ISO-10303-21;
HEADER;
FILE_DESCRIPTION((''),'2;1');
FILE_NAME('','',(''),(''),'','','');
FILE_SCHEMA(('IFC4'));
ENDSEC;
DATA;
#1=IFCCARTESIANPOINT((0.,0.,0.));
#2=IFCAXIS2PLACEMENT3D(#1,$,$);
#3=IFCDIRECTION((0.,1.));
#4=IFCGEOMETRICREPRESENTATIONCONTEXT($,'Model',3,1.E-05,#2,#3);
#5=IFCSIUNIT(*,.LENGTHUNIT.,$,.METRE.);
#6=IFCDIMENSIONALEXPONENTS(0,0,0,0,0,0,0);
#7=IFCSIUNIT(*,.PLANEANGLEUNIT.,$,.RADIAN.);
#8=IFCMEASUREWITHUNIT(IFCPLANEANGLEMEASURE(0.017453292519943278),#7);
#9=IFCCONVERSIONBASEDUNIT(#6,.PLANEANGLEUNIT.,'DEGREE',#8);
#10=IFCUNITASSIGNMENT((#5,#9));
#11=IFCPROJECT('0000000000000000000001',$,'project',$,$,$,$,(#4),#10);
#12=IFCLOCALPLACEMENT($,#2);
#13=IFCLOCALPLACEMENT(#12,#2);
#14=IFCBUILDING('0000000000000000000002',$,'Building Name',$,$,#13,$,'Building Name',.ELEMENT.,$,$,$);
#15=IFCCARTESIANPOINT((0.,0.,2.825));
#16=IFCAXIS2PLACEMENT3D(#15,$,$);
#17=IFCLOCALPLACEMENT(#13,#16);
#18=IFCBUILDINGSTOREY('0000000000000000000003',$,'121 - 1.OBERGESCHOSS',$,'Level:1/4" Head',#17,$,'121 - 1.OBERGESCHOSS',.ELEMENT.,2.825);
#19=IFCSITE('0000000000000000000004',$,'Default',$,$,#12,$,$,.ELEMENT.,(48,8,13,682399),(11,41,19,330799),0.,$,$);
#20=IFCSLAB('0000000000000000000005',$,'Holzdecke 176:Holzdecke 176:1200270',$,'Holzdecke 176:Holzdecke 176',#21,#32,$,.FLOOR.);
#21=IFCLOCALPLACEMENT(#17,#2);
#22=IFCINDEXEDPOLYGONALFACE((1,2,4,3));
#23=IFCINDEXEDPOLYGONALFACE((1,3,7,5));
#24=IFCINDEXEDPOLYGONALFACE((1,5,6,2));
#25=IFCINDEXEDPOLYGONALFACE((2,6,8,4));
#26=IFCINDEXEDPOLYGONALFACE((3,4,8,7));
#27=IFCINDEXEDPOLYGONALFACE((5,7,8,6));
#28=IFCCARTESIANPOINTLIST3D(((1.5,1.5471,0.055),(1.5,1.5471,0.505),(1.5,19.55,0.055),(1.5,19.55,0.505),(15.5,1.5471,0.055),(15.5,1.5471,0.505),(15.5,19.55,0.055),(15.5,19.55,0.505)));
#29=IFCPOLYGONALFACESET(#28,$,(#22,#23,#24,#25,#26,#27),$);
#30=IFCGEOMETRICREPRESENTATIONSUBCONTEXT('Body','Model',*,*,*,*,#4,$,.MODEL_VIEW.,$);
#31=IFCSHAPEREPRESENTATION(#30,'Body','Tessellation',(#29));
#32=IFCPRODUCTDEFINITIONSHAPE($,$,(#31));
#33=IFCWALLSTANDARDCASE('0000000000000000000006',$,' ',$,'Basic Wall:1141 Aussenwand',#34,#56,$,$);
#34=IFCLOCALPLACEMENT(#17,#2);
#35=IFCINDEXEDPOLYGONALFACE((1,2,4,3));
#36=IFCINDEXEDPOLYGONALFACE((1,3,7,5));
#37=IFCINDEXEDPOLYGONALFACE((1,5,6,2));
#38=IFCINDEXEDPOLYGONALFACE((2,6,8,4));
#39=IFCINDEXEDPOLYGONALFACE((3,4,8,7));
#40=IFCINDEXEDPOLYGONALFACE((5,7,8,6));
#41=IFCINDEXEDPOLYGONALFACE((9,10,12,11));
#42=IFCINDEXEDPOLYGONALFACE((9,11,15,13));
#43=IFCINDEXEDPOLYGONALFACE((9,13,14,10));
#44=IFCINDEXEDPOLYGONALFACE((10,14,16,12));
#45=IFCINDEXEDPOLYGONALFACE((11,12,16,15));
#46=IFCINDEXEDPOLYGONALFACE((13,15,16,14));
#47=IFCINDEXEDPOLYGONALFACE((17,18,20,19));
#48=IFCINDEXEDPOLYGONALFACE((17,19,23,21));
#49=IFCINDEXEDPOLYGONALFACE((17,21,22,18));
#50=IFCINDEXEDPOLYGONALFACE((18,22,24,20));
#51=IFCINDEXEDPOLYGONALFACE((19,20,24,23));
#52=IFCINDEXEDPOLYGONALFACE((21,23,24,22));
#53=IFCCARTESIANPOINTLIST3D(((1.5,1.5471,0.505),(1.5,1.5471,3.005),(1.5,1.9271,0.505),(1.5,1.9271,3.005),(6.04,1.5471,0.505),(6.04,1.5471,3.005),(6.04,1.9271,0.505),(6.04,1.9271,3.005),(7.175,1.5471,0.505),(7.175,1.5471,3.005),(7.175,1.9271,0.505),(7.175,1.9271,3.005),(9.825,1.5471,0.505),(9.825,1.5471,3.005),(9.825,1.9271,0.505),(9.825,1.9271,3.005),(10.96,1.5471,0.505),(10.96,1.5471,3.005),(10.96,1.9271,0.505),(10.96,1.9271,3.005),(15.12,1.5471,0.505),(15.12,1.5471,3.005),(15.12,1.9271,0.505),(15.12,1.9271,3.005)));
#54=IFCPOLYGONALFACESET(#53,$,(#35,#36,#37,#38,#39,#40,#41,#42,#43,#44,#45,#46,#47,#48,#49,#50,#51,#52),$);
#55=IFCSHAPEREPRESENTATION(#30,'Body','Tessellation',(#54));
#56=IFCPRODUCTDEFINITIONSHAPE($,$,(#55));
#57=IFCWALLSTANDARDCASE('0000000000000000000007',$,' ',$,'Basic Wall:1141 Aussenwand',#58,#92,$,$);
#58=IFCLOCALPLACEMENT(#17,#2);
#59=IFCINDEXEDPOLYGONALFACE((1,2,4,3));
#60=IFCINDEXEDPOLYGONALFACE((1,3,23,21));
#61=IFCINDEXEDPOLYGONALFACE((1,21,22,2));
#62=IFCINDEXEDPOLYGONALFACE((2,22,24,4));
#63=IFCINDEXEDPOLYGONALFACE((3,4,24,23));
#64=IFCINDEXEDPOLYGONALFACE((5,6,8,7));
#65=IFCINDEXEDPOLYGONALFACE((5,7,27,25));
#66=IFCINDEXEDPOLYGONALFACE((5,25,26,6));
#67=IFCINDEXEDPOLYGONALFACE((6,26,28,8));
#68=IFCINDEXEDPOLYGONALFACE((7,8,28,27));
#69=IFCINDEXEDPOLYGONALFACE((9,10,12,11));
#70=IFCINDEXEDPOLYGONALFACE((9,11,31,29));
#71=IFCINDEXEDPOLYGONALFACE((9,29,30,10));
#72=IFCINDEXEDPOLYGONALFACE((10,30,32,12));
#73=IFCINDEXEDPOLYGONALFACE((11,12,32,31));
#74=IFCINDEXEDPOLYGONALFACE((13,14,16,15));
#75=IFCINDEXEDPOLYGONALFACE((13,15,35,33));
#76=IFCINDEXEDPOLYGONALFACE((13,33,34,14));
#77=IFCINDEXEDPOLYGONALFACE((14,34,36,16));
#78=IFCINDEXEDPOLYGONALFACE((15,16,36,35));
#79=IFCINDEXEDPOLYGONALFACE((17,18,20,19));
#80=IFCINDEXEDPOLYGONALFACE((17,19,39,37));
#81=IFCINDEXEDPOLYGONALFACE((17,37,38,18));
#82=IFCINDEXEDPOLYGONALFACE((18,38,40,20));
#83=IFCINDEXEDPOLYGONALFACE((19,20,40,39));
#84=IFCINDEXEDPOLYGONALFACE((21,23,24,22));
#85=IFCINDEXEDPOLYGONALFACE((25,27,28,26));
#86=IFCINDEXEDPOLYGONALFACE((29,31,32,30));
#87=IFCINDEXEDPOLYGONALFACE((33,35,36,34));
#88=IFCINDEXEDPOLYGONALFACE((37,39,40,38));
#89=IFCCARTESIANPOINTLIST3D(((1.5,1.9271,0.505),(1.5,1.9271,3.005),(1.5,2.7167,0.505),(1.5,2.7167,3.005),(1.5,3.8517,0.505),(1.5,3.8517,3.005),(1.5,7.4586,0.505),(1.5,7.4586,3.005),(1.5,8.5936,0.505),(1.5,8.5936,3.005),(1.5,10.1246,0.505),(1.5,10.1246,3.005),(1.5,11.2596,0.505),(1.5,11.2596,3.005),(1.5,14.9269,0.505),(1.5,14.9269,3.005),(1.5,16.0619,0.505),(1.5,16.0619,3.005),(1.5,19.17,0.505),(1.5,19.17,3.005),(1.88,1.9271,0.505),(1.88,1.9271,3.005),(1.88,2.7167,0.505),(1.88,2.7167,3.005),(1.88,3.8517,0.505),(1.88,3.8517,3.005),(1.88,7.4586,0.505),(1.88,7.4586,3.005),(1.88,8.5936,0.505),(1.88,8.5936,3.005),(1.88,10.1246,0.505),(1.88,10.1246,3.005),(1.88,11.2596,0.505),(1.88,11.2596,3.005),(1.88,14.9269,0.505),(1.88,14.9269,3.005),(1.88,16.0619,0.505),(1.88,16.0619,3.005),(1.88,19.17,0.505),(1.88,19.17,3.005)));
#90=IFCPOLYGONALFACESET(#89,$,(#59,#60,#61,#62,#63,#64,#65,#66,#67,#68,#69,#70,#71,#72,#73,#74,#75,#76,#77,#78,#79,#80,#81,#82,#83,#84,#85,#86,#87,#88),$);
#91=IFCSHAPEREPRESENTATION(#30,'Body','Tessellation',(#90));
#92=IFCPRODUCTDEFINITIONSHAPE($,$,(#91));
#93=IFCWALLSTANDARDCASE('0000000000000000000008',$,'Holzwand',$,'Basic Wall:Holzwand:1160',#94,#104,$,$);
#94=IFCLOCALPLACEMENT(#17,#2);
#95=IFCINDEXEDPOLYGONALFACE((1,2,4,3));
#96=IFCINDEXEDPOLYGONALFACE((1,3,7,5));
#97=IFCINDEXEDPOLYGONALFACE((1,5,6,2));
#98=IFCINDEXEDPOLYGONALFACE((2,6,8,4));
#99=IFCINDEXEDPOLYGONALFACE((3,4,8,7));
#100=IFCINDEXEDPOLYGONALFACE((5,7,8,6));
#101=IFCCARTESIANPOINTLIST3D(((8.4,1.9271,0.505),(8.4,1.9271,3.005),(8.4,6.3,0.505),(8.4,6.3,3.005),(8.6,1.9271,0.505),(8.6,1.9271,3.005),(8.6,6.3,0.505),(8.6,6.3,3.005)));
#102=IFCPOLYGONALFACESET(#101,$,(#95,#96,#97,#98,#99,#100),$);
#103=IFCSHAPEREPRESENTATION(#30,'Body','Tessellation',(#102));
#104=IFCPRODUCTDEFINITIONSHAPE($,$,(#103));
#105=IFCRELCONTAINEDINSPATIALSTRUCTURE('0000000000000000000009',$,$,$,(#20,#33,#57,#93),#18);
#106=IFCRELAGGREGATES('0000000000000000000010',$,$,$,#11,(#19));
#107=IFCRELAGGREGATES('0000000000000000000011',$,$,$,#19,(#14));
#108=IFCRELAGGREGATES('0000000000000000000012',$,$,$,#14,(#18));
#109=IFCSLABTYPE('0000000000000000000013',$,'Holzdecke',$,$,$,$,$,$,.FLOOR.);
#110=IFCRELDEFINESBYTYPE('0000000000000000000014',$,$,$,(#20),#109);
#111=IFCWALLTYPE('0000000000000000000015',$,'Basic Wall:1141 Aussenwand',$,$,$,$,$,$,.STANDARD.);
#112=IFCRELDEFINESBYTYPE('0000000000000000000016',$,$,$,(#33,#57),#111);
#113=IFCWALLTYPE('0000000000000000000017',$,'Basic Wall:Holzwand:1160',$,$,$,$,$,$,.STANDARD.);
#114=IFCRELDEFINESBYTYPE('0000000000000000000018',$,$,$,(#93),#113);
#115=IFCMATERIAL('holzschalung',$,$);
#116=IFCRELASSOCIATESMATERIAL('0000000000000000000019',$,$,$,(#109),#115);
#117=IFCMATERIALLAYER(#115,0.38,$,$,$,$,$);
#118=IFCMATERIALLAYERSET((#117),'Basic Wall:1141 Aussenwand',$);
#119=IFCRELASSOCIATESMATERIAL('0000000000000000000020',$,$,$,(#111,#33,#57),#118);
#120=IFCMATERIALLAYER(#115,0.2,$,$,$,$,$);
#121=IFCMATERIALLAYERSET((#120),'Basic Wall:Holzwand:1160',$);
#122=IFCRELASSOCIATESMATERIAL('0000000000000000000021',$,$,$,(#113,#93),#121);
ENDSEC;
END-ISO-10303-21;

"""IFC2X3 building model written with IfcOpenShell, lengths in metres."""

from ifc_helpers import new_model, entity, si_unit, converted_unit, direction, frame, frame_2d, origin, place, context, subcontext, project, spatial, rectangle, extrude, material, layer, layer_set, layer_usage, type_object, element, save


model = new_model("IFC2X3")

# Units and contexts
model_context = context("Model", 3, precision=1e-05, world=origin(), true_north=direction((0.0, 1.0)))
body_context = subcontext(model_context, "Body", "Model", "MODEL_VIEW")
ifc_project = project(units=[si_unit("LENGTHUNIT", "METRE"), converted_unit("PLANEANGLEUNIT", "DEGREE", entity("IfcPlaneAngleMeasure", 0.017453292519943278), si_unit("PLANEANGLEUNIT", "RADIAN"), dimensions=[0, 0, 0, 0, 0, 0, 0])], contexts=[model_context])

# Site, building, storey
site_placement = place(None, origin())
site = spatial("IfcSite", under=ifc_project, at=site_placement, Name="Default", CompositionType="ELEMENT", RefLatitude=(48, 8, 13, 682399), RefLongitude=(11, 41, 19, 330799), RefElevation=0.0)
building_placement = place(site_placement, origin())
building = spatial("IfcBuilding", under=site, at=building_placement, Name="Building Name", LongName="Building Name", CompositionType="ELEMENT")
storey_placement = place(building_placement, frame((0.0, 0.0, 2.825)))
storey = spatial("IfcBuildingStorey", under=building, at=storey_placement, Name="121 - 1.OBERGESCHOSS", ObjectType="Level:1/4\" Head", LongName="121 - 1.OBERGESCHOSS", CompositionType="ELEMENT", Elevation=2.825)

# Slab
ifc_material_1 = material(Name="holzschalung")
slab_type = type_object("IfcSlabType", Name="Holzdecke", PredefinedType="FLOOR", material=ifc_material_1)
slab_placement = place(storey_placement, origin())
element("IfcSlab", 1, at=slab_placement, inside=storey, type_object=slab_type, Name="Holzdecke 176:Holzdecke 176:1200270", ObjectType="Holzdecke 176:Holzdecke 176", PredefinedType="FLOOR", context=body_context, shape_type="SweptSolid", body=[
    extrude(rectangle(XDim=14.0, YDim=18.0029, at=frame_2d((0.0, 0.0), x_axis=(1.0, 0.0))), frame((8.5, 10.5486, 0.055), z_axis=(0.0, 0.0, 1.0), x_axis=(-1.0, 0.0, 0.0)), (0.0, 0.0, 1.0), 0.45),
])

# Walls, openings
ifc_layer_1 = layer(ifc_material_1, 0.38)
ifc_layer_set_1 = layer_set([ifc_layer_1], Name="Basic Wall:1141 Aussenwand")
ifc_layer_usage_1 = layer_usage(ifc_layer_set_1, "AXIS2", "NEGATIVE", 0.19)
wall_type_1 = type_object("IfcWallType", Name="Basic Wall:1141 Aussenwand", PredefinedType="STANDARD", material=ifc_layer_set_1)
wall_1_placement = place(storey_placement, frame((15.12, 1.7371, 0.505), z_axis=(0.0, 0.0, 1.0), x_axis=(-1.0, 0.0, 0.0)))
wall_1 = element("IfcWallStandardCase", 2, at=wall_1_placement, inside=storey, type_object=wall_type_1, material=ifc_layer_usage_1, Name=" ", ObjectType="Basic Wall:1141 Aussenwand", context=body_context, shape_type="SweptSolid", body=[
    extrude(rectangle(XDim=13.62, YDim=0.38, at=frame_2d((6.81, 0.0), x_axis=(-1.0, 0.0))), origin(), (0.0, 0.0, 1.0), 2.5),
])
opening_1_placement = place(wall_1_placement, origin())
element("IfcOpeningElement", 3, at=opening_1_placement, cuts=wall_1, ObjectType="Opening", context=body_context, shape_type="SweptSolid", body=[
    extrude(rectangle(XDim=2.5, YDim=1.135, at=frame_2d((0.0, 0.0), x_axis=(1.0, 0.0))), frame((4.7275, -0.19, 1.25), z_axis=(0.0, 1.0, 0.0), x_axis=(0.0, 0.0, 1.0)), (0.0, 0.0, 1.0), 0.38),
])
opening_2_placement = place(wall_1_placement, origin())
element("IfcOpeningElement", 4, at=opening_2_placement, cuts=wall_1, ObjectType="Opening", context=body_context, shape_type="SweptSolid", body=[
    extrude(rectangle(XDim=2.5, YDim=1.135, at=frame_2d((0.0, 0.0), x_axis=(1.0, 0.0))), frame((8.5125, -0.19, 1.25), z_axis=(0.0, 1.0, 0.0), x_axis=(0.0, 0.0, 1.0)), (0.0, 0.0, 1.0), 0.38),
])
ifc_layer_usage_2 = layer_usage(ifc_layer_set_1, "AXIS2", "NEGATIVE", 0.19)
wall_2_placement = place(storey_placement, frame((1.69, 1.9271, 0.505), z_axis=(0.0, 0.0, 1.0), x_axis=(0.0, 1.0, 0.0)))
wall_2 = element("IfcWallStandardCase", 5, at=wall_2_placement, inside=storey, type_object=wall_type_1, material=ifc_layer_usage_2, Name=" ", ObjectType="Basic Wall:1141 Aussenwand", context=body_context, shape_type="SweptSolid", body=[
    extrude(rectangle(XDim=17.2429, YDim=0.38, at=frame_2d((8.6214, 0.0), x_axis=(-1.0, 0.0))), origin(), (0.0, 0.0, 1.0), 2.5),
])
opening_3_placement = place(wall_2_placement, origin())
element("IfcOpeningElement", 6, at=opening_3_placement, cuts=wall_2, ObjectType="Opening", context=body_context, shape_type="SweptSolid", body=[
    extrude(rectangle(XDim=2.5, YDim=1.135, at=frame_2d((0.0, 0.0), x_axis=(1.0, 0.0))), frame((13.5673, -0.19, 1.25), z_axis=(0.0, 1.0, 0.0), x_axis=(0.0, 0.0, 1.0)), (0.0, 0.0, 1.0), 0.38),
])
opening_4_placement = place(wall_2_placement, origin())
element("IfcOpeningElement", 7, at=opening_4_placement, cuts=wall_2, ObjectType="Opening", context=body_context, shape_type="SweptSolid", body=[
    extrude(rectangle(XDim=2.5, YDim=1.135, at=frame_2d((0.0, 0.0), x_axis=(1.0, 0.0))), frame((8.765, -0.19, 1.25), z_axis=(0.0, 1.0, 0.0), x_axis=(0.0, 0.0, 1.0)), (0.0, 0.0, 1.0), 0.38),
])
opening_5_placement = place(wall_2_placement, origin())
element("IfcOpeningElement", 8, at=opening_5_placement, cuts=wall_2, ObjectType="Opening", context=body_context, shape_type="SweptSolid", body=[
    extrude(rectangle(XDim=2.5, YDim=1.135, at=frame_2d((0.0, 0.0), x_axis=(1.0, 0.0))), frame((6.0989, -0.19, 1.25), z_axis=(0.0, 1.0, 0.0), x_axis=(0.0, 0.0, 1.0)), (0.0, 0.0, 1.0), 0.38),
])
opening_6_placement = place(wall_2_placement, origin())
element("IfcOpeningElement", 9, at=opening_6_placement, cuts=wall_2, ObjectType="Opening", context=body_context, shape_type="SweptSolid", body=[
    extrude(rectangle(XDim=2.5, YDim=1.135, at=frame_2d((0.0, 0.0), x_axis=(1.0, 0.0))), frame((1.3571, -0.19, 1.25), z_axis=(0.0, 1.0, 0.0), x_axis=(0.0, 0.0, 1.0)), (0.0, 0.0, 1.0), 0.38),
])

# Wall
ifc_layer_2 = layer(ifc_material_1, 0.2)
ifc_layer_set_2 = layer_set([ifc_layer_2], Name="Basic Wall:Holzwand:1160")
ifc_layer_usage_3 = layer_usage(ifc_layer_set_2, "AXIS2", "NEGATIVE", 0.1)
wall_type_2 = type_object("IfcWallType", Name="Basic Wall:Holzwand:1160", PredefinedType="STANDARD", material=ifc_layer_set_2)
wall_3_placement = place(storey_placement, frame((8.5, 1.9271, 0.505), z_axis=(0.0, 0.0, 1.0), x_axis=(0.0, 1.0, 0.0)))
element("IfcWallStandardCase", 10, at=wall_3_placement, inside=storey, type_object=wall_type_2, material=ifc_layer_usage_3, Name="Holzwand", ObjectType="Basic Wall:Holzwand:1160", context=body_context, shape_type="SweptSolid", body=[
    extrude(rectangle(XDim=4.3729, YDim=0.2, at=frame_2d((2.1864, 0.0), x_axis=(-1.0, 0.0))), origin(), (0.0, 0.0, 1.0), 2.5),
])

save(model, "model.ifc")
